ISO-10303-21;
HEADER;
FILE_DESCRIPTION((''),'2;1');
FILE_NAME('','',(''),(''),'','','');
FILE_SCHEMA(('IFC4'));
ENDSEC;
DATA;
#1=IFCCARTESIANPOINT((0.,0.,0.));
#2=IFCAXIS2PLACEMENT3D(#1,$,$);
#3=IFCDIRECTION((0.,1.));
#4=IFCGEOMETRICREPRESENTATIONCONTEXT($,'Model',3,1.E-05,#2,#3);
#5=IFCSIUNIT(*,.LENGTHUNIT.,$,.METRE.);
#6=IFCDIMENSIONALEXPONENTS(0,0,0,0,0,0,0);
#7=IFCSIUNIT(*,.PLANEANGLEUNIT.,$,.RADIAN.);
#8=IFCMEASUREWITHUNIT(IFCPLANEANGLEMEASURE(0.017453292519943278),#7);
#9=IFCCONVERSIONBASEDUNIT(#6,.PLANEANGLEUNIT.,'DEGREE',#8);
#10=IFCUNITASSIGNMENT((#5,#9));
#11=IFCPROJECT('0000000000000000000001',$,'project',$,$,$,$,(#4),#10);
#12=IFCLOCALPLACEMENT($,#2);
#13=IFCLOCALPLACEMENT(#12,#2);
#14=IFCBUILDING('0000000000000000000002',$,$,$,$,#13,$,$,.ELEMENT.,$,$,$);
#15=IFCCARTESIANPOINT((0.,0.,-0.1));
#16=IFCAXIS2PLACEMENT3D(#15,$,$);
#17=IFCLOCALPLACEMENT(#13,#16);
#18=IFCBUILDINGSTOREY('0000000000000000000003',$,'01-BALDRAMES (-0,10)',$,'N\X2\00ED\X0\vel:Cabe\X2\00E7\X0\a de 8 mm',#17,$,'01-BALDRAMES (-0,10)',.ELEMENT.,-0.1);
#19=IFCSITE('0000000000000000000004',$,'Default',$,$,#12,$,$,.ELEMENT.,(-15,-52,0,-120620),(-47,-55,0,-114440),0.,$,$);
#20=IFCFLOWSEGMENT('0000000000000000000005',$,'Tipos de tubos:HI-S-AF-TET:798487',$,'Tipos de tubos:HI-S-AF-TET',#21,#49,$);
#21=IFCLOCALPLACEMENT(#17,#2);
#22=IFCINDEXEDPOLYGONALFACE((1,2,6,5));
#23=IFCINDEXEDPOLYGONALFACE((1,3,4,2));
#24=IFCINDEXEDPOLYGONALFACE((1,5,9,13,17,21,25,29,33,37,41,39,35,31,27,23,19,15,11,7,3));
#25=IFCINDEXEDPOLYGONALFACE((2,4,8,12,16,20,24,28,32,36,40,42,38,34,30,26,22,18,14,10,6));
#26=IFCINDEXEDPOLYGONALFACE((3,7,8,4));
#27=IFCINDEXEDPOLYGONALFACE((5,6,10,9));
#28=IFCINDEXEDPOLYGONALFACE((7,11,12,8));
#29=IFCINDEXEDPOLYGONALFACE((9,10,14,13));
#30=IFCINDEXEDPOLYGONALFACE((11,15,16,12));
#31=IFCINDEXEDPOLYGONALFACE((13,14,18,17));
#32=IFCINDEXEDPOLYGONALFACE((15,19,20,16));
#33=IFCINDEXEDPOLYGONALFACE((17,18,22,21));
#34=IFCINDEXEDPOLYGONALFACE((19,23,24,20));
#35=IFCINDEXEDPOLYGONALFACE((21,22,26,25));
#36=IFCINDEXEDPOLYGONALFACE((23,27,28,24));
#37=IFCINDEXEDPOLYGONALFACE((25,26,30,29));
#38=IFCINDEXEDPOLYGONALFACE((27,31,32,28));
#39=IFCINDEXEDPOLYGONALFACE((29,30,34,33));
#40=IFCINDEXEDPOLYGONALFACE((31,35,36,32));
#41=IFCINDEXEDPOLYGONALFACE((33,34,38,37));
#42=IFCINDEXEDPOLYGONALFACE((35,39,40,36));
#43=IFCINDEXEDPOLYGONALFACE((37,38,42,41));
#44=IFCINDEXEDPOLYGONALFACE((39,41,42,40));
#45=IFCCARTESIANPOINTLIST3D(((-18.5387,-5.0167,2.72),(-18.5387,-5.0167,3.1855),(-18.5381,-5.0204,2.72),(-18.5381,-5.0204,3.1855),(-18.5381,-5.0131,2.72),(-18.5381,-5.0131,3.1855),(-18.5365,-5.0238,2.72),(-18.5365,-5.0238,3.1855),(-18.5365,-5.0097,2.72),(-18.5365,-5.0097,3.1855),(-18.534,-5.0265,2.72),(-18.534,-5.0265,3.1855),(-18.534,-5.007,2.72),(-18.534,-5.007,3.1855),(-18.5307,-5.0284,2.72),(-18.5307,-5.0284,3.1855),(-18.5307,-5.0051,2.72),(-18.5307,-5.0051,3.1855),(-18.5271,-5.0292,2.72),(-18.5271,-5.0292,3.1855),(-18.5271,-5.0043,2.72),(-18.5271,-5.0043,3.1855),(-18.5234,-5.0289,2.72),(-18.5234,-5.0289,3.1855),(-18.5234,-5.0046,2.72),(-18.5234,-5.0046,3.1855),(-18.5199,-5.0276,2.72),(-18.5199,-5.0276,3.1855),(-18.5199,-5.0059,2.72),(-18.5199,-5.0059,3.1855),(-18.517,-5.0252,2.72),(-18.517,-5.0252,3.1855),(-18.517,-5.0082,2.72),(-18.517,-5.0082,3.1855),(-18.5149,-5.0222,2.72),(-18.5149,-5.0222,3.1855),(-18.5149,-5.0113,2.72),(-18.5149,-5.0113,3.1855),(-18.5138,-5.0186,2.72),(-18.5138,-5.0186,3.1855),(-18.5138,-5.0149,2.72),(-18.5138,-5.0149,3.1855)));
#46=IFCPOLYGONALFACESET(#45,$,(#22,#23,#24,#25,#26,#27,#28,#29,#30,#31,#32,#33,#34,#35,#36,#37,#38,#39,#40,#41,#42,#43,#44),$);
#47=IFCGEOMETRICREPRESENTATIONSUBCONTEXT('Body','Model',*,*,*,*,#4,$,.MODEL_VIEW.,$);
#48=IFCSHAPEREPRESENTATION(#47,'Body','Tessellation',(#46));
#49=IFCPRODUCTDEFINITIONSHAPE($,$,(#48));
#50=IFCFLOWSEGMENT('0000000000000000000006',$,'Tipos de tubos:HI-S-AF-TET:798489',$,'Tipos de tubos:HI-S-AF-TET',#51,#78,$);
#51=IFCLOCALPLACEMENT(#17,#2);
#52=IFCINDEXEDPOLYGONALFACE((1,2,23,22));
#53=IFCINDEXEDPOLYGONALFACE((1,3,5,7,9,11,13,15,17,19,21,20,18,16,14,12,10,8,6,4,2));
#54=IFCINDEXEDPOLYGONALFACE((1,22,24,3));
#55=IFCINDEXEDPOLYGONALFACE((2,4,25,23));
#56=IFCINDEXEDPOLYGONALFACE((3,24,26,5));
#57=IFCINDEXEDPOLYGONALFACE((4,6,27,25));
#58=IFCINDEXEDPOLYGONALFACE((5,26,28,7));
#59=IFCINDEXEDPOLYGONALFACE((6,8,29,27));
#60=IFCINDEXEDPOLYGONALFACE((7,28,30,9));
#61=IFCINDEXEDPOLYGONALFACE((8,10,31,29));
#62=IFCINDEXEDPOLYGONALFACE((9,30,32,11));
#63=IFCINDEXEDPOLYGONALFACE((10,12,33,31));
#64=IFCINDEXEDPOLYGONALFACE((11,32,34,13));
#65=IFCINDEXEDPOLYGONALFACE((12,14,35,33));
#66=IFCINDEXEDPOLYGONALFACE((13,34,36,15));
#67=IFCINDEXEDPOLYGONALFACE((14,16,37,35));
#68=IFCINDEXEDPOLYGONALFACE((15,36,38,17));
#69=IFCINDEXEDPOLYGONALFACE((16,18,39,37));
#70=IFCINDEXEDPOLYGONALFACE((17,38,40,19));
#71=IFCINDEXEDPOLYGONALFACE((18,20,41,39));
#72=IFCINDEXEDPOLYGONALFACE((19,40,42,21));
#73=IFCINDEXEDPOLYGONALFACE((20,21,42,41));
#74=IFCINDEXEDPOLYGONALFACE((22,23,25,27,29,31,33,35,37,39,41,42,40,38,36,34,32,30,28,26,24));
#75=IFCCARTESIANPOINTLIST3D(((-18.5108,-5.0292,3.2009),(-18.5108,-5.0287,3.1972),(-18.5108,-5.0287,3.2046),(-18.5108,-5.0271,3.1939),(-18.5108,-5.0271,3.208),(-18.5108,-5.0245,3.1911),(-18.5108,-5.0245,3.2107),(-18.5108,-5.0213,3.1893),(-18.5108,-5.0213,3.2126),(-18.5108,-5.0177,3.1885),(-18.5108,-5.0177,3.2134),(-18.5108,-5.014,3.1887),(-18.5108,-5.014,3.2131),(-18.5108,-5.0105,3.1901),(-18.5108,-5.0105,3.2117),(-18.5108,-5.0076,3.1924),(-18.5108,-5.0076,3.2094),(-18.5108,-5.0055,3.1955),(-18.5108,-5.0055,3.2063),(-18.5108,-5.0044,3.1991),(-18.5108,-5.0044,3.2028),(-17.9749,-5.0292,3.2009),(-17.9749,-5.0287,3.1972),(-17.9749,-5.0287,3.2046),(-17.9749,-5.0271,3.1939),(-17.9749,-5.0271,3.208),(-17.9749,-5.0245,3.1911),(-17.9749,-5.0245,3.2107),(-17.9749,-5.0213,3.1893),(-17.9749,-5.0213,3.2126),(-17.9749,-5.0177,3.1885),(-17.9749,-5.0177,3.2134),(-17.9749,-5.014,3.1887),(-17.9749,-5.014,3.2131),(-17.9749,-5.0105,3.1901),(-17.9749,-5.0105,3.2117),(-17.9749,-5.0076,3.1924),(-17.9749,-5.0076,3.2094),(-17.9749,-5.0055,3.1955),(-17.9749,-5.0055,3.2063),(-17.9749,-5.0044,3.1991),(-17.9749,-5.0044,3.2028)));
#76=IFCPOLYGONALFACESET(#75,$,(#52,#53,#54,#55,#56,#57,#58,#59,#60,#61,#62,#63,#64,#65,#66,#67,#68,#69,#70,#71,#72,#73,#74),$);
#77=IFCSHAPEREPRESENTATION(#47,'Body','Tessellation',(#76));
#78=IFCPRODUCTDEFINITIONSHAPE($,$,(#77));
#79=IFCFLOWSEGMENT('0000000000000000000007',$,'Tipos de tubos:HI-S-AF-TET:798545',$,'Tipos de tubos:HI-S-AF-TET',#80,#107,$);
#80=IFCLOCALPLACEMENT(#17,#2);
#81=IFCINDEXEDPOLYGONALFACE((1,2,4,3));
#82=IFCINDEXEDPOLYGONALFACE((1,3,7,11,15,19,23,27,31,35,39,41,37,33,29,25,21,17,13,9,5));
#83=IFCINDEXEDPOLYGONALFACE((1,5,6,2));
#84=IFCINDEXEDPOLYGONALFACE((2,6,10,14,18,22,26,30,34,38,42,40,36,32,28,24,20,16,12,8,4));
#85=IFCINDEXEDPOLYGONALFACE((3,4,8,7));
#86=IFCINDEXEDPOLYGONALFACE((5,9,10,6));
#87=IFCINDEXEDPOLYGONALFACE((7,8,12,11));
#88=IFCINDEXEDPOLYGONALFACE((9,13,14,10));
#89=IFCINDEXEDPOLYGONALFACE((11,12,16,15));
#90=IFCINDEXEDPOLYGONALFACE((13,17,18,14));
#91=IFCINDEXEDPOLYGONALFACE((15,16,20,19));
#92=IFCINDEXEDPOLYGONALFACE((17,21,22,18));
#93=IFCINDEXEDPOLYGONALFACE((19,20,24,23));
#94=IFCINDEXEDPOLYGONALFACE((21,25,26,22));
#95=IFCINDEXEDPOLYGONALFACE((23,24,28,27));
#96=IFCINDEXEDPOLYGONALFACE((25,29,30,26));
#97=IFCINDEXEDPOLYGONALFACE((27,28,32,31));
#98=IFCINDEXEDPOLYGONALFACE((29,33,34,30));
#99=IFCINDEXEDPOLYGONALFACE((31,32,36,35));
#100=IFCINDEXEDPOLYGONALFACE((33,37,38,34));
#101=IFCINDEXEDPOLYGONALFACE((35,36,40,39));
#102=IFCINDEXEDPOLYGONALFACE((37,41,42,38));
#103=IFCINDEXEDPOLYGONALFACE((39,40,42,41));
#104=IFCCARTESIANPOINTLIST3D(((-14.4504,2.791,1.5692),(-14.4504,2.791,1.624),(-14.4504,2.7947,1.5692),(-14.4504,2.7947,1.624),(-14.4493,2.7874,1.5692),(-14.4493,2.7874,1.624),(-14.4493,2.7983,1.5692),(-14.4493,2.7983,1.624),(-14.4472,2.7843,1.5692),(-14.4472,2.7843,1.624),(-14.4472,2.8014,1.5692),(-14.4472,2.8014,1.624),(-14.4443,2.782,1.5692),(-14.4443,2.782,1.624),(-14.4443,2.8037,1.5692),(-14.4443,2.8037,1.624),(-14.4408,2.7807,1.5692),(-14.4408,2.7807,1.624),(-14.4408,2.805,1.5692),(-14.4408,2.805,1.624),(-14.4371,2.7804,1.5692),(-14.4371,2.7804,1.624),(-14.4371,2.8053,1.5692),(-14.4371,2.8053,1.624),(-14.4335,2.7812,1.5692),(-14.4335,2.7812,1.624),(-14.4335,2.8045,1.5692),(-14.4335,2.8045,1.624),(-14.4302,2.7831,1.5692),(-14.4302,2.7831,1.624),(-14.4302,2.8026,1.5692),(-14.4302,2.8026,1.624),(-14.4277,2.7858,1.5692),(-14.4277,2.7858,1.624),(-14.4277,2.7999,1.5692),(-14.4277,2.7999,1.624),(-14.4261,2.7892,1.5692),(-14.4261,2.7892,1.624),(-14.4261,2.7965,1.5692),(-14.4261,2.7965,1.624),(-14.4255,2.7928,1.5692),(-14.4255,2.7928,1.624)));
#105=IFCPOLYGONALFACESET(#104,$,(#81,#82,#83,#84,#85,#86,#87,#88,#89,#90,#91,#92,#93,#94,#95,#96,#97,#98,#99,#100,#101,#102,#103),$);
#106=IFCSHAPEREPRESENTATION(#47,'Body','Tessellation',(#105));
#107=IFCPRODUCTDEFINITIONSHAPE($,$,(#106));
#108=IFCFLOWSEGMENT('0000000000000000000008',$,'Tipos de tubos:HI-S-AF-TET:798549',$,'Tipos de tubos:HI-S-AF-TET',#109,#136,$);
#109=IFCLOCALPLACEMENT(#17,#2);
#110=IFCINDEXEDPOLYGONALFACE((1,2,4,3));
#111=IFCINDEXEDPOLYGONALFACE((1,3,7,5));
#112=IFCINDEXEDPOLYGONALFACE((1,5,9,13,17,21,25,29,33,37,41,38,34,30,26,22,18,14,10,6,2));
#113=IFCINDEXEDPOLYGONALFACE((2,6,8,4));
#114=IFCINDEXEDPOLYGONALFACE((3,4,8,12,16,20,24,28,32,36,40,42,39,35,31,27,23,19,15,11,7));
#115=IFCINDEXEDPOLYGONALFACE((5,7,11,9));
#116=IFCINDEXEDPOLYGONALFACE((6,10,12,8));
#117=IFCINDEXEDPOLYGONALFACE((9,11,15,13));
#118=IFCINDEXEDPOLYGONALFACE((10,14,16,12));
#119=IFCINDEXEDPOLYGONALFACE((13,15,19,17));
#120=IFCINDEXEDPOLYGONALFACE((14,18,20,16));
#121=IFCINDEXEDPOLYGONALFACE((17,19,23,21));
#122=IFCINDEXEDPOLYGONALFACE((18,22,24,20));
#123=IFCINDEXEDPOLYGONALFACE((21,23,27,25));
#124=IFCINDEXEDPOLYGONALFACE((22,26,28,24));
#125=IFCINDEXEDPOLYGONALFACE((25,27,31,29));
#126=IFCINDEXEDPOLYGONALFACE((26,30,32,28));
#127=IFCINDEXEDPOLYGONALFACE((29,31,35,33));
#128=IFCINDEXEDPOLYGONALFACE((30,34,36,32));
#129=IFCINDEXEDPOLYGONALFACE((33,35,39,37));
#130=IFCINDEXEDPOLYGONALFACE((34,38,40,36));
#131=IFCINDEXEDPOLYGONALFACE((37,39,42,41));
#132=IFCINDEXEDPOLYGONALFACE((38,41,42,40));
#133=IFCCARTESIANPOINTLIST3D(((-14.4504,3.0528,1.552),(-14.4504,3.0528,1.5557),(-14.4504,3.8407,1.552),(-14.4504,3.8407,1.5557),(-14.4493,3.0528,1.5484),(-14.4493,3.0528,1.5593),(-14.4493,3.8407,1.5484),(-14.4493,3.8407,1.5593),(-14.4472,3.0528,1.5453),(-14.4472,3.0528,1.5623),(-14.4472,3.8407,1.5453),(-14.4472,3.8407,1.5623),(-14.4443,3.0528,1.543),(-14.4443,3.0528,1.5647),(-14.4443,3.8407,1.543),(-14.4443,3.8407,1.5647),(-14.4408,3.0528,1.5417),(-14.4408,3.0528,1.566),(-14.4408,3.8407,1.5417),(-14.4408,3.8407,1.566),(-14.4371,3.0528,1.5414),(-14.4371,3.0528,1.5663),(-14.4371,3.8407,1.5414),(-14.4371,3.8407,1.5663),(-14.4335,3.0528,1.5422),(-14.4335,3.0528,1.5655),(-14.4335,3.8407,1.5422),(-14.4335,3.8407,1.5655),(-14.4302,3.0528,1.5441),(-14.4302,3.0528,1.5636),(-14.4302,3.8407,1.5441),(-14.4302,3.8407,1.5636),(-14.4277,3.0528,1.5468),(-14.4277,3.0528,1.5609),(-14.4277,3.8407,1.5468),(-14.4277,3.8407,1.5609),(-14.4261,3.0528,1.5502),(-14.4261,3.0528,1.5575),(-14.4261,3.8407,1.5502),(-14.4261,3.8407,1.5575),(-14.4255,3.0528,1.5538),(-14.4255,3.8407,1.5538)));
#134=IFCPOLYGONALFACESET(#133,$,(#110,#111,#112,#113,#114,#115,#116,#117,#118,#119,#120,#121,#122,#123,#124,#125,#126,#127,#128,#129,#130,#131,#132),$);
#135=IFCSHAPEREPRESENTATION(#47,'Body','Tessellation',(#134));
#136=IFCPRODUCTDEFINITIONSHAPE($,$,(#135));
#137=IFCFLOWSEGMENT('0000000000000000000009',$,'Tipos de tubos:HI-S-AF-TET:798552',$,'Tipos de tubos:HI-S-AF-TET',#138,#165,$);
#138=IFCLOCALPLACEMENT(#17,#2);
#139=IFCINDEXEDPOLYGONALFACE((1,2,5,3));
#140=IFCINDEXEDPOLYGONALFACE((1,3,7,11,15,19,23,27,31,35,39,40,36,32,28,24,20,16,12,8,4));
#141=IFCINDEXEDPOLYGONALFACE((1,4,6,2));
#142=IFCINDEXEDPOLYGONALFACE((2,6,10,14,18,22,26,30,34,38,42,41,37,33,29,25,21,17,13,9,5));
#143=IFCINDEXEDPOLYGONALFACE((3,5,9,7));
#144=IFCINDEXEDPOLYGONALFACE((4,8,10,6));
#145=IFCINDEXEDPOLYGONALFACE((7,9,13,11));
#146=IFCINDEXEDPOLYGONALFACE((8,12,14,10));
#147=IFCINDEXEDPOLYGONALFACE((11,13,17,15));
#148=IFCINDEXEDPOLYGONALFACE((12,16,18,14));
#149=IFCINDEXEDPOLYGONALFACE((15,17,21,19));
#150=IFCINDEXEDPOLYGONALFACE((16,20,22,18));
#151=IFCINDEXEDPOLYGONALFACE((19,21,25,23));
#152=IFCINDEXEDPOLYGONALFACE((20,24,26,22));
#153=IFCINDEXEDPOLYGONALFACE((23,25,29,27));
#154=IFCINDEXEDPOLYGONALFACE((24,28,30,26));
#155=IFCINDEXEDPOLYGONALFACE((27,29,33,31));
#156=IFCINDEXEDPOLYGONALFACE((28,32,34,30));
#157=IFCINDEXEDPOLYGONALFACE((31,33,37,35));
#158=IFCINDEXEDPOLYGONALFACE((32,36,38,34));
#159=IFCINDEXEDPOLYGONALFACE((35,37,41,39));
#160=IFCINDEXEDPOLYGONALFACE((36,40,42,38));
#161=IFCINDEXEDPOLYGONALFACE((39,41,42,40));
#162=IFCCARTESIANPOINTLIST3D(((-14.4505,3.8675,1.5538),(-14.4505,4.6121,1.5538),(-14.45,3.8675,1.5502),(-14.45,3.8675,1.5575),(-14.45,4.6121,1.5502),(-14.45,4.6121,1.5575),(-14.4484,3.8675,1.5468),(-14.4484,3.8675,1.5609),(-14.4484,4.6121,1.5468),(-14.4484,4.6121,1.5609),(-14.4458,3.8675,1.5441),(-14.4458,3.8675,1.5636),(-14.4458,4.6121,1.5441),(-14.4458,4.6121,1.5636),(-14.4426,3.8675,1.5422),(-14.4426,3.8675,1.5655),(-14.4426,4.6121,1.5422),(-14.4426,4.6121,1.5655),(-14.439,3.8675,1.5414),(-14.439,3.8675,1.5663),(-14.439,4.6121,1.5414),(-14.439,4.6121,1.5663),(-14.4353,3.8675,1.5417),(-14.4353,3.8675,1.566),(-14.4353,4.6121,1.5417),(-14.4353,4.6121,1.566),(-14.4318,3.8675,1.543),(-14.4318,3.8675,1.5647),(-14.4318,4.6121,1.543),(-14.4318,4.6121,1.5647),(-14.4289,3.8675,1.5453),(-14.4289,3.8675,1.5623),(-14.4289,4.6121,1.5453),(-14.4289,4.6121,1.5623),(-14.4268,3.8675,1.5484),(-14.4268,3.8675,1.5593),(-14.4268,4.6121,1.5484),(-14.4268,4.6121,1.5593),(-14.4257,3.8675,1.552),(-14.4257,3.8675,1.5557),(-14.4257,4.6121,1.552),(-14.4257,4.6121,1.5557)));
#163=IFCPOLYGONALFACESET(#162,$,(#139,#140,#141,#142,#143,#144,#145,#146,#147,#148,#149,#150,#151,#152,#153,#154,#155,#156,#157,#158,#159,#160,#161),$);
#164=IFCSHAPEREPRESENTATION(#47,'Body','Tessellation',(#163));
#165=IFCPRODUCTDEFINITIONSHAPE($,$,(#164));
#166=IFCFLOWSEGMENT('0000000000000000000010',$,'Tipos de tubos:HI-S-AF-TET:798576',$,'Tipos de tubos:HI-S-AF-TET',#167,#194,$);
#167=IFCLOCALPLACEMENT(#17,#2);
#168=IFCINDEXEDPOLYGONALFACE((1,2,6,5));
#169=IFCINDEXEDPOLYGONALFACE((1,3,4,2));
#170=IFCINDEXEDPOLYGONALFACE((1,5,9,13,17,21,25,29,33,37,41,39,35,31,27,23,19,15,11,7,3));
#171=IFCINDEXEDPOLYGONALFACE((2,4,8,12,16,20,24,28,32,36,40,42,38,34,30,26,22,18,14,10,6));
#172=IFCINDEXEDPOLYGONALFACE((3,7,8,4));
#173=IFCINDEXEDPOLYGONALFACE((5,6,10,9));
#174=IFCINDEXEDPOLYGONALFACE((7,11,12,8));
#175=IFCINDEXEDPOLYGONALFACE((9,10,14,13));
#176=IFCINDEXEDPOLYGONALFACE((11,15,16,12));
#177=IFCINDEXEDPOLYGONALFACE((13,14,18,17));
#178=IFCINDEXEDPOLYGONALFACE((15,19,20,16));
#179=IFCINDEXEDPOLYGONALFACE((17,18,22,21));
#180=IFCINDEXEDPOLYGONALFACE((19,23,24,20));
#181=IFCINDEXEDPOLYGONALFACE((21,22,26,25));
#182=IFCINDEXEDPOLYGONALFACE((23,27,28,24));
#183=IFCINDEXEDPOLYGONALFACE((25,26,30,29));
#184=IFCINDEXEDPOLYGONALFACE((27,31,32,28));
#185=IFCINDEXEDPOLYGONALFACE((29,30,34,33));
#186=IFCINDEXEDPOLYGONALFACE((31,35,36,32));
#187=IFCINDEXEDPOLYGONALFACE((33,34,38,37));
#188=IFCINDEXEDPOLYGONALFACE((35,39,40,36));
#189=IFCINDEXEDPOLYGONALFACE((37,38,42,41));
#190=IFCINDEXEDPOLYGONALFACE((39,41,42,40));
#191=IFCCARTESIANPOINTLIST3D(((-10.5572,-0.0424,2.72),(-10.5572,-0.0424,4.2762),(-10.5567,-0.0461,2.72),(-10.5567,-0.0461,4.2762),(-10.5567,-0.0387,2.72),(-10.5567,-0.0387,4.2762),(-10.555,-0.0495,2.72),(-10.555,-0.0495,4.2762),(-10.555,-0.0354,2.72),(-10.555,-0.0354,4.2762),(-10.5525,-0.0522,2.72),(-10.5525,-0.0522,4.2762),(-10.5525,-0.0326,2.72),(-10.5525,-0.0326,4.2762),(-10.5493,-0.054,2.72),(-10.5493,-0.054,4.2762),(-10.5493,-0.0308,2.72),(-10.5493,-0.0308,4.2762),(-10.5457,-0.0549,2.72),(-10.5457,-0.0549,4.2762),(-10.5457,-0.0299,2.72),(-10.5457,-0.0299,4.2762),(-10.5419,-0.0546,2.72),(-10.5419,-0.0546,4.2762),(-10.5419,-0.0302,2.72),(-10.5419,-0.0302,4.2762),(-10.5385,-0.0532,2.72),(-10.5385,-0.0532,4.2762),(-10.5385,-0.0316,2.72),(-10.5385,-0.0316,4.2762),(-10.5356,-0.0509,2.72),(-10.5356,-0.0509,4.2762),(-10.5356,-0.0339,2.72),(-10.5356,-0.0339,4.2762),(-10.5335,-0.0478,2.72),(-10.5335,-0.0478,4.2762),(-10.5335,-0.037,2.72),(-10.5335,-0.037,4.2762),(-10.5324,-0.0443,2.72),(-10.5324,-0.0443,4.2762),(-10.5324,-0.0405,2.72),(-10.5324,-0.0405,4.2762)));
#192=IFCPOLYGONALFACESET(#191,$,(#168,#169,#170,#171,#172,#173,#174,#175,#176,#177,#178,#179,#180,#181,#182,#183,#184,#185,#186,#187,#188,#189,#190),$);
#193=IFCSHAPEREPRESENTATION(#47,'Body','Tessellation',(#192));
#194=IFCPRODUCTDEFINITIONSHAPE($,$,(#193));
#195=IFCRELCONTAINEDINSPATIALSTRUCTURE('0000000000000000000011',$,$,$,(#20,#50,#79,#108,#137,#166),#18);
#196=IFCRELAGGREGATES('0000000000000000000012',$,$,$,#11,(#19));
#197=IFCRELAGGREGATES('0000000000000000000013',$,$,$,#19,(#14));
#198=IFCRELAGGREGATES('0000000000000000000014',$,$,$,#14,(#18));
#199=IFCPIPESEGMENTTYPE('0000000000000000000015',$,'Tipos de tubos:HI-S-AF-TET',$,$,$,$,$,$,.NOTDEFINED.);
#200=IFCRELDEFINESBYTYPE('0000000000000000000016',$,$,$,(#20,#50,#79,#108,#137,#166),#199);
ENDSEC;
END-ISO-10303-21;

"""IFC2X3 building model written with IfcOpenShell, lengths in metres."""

from ifc_helpers import new_model, entity, si_unit, converted_unit, direction, frame, frame_2d, origin, origin_2d_with_axis, place, context, subcontext, project, spatial, circle, extrude, type_object, element, save


model = new_model("IFC2X3")

# Units and contexts
model_context = context("Model", 3, precision=1e-05, world=origin(), true_north=direction((0.0, 1.0)))
body_context = subcontext(model_context, "Body", "Model", "MODEL_VIEW")
ifc_project = project(units=[si_unit("LENGTHUNIT", "METRE"), converted_unit("PLANEANGLEUNIT", "DEGREE", entity("IfcPlaneAngleMeasure", 0.017453292519943278), si_unit("PLANEANGLEUNIT", "RADIAN"), dimensions=[0, 0, 0, 0, 0, 0, 0])], contexts=[model_context])

# Site, building, storey
site_placement = place(None, origin())
site = spatial("IfcSite", under=ifc_project, at=site_placement, Name="Default", CompositionType="ELEMENT", RefLatitude=(-15, -52, 0, -120620), RefLongitude=(-47, -55, 0, -114440), RefElevation=0.0)
building_placement = place(site_placement, origin())
building = spatial("IfcBuilding", under=site, at=building_placement, CompositionType="ELEMENT")
storey_placement = place(building_placement, frame((0.0, 0.0, -0.1)))
storey = spatial("IfcBuildingStorey", under=building, at=storey_placement, Name="01-BALDRAMES (-0,10)", ObjectType="Nível:Cabeça de 8 mm", LongName="01-BALDRAMES (-0,10)", CompositionType="ELEMENT", Elevation=-0.1)

# Flow segments
pipe_segment_type_1 = type_object("IfcPipeSegmentType", Name="Tipos de tubos:HI-S-AF-TET", PredefinedType="NOTDEFINED")
flow_segment_1_placement = place(storey_placement, origin())
element("IfcFlowSegment", 1, at=flow_segment_1_placement, inside=storey, type_object=pipe_segment_type_1, Name="Tipos de tubos:HI-S-AF-TET:798487", ObjectType="Tipos de tubos:HI-S-AF-TET", context=body_context, shape_type="SweptSolid", body=[
    extrude(circle(Radius=0.0125, at=frame_2d((0.0, 0.0), x_axis=(1.0, 0.0))), frame((-18.5262, -5.0167, 2.72), z_axis=(0.0, 0.0, 1.0), x_axis=(-1.0, 0.0, 0.0)), (0.0, 0.0, 1.0), 0.4655),
])
flow_segment_2_placement = place(storey_placement, origin())
element("IfcFlowSegment", 2, at=flow_segment_2_placement, inside=storey, type_object=pipe_segment_type_1, Name="Tipos de tubos:HI-S-AF-TET:798489", ObjectType="Tipos de tubos:HI-S-AF-TET", context=body_context, shape_type="SweptSolid", body=[
    extrude(circle(Radius=0.0125, at=frame_2d((0.0, 0.0), x_axis=(1.0, 0.0))), frame((-18.5108, -5.0167, 3.2009), z_axis=(1.0, 0.0, 0.0), x_axis=(0.0, -1.0, 0.0)), (0.0, 0.0, 1.0), 0.5359),
])
flow_segment_3_placement = place(storey_placement, origin())
element("IfcFlowSegment", 3, at=flow_segment_3_placement, inside=storey, type_object=pipe_segment_type_1, Name="Tipos de tubos:HI-S-AF-TET:798545", ObjectType="Tipos de tubos:HI-S-AF-TET", context=body_context, shape_type="SweptSolid", body=[
    extrude(circle(Radius=0.0125, at=origin_2d_with_axis()), frame((-14.438, 2.7928, 1.5692)), (0.0, 0.0, 1.0), 0.0548),
])
flow_segment_4_placement = place(storey_placement, origin())
element("IfcFlowSegment", 4, at=flow_segment_4_placement, inside=storey, type_object=pipe_segment_type_1, Name="Tipos de tubos:HI-S-AF-TET:798549", ObjectType="Tipos de tubos:HI-S-AF-TET", context=body_context, shape_type="SweptSolid", body=[
    extrude(circle(Radius=0.0125, at=origin_2d_with_axis()), frame((-14.438, 3.0528, 1.5538), z_axis=(0.0, 1.0, 0.0), x_axis=(1.0, 0.0, 0.0)), (0.0, 0.0, 1.0), 0.7879),
])
flow_segment_5_placement = place(storey_placement, origin())
element("IfcFlowSegment", 5, at=flow_segment_5_placement, inside=storey, type_object=pipe_segment_type_1, Name="Tipos de tubos:HI-S-AF-TET:798552", ObjectType="Tipos de tubos:HI-S-AF-TET", context=body_context, shape_type="SweptSolid", body=[
    extrude(circle(Radius=0.0125, at=origin_2d_with_axis()), frame((-14.438, 3.8675, 1.5538), z_axis=(0.0, 1.0, 0.0), x_axis=(-1.0, 0.0, 0.0)), (0.0, 0.0, 1.0), 0.7445),
])
flow_segment_6_placement = place(storey_placement, origin())
element("IfcFlowSegment", 6, at=flow_segment_6_placement, inside=storey, type_object=pipe_segment_type_1, Name="Tipos de tubos:HI-S-AF-TET:798576", ObjectType="Tipos de tubos:HI-S-AF-TET", context=body_context, shape_type="SweptSolid", body=[
    extrude(circle(Radius=0.0125, at=frame_2d((0.0, 0.0), x_axis=(1.0, 0.0))), frame((-10.5447, -0.0424, 2.72), z_axis=(0.0, 0.0, 1.0), x_axis=(-1.0, 0.0, 0.0)), (0.0, 0.0, 1.0), 1.5562),
])

save(model, "model.ifc")
